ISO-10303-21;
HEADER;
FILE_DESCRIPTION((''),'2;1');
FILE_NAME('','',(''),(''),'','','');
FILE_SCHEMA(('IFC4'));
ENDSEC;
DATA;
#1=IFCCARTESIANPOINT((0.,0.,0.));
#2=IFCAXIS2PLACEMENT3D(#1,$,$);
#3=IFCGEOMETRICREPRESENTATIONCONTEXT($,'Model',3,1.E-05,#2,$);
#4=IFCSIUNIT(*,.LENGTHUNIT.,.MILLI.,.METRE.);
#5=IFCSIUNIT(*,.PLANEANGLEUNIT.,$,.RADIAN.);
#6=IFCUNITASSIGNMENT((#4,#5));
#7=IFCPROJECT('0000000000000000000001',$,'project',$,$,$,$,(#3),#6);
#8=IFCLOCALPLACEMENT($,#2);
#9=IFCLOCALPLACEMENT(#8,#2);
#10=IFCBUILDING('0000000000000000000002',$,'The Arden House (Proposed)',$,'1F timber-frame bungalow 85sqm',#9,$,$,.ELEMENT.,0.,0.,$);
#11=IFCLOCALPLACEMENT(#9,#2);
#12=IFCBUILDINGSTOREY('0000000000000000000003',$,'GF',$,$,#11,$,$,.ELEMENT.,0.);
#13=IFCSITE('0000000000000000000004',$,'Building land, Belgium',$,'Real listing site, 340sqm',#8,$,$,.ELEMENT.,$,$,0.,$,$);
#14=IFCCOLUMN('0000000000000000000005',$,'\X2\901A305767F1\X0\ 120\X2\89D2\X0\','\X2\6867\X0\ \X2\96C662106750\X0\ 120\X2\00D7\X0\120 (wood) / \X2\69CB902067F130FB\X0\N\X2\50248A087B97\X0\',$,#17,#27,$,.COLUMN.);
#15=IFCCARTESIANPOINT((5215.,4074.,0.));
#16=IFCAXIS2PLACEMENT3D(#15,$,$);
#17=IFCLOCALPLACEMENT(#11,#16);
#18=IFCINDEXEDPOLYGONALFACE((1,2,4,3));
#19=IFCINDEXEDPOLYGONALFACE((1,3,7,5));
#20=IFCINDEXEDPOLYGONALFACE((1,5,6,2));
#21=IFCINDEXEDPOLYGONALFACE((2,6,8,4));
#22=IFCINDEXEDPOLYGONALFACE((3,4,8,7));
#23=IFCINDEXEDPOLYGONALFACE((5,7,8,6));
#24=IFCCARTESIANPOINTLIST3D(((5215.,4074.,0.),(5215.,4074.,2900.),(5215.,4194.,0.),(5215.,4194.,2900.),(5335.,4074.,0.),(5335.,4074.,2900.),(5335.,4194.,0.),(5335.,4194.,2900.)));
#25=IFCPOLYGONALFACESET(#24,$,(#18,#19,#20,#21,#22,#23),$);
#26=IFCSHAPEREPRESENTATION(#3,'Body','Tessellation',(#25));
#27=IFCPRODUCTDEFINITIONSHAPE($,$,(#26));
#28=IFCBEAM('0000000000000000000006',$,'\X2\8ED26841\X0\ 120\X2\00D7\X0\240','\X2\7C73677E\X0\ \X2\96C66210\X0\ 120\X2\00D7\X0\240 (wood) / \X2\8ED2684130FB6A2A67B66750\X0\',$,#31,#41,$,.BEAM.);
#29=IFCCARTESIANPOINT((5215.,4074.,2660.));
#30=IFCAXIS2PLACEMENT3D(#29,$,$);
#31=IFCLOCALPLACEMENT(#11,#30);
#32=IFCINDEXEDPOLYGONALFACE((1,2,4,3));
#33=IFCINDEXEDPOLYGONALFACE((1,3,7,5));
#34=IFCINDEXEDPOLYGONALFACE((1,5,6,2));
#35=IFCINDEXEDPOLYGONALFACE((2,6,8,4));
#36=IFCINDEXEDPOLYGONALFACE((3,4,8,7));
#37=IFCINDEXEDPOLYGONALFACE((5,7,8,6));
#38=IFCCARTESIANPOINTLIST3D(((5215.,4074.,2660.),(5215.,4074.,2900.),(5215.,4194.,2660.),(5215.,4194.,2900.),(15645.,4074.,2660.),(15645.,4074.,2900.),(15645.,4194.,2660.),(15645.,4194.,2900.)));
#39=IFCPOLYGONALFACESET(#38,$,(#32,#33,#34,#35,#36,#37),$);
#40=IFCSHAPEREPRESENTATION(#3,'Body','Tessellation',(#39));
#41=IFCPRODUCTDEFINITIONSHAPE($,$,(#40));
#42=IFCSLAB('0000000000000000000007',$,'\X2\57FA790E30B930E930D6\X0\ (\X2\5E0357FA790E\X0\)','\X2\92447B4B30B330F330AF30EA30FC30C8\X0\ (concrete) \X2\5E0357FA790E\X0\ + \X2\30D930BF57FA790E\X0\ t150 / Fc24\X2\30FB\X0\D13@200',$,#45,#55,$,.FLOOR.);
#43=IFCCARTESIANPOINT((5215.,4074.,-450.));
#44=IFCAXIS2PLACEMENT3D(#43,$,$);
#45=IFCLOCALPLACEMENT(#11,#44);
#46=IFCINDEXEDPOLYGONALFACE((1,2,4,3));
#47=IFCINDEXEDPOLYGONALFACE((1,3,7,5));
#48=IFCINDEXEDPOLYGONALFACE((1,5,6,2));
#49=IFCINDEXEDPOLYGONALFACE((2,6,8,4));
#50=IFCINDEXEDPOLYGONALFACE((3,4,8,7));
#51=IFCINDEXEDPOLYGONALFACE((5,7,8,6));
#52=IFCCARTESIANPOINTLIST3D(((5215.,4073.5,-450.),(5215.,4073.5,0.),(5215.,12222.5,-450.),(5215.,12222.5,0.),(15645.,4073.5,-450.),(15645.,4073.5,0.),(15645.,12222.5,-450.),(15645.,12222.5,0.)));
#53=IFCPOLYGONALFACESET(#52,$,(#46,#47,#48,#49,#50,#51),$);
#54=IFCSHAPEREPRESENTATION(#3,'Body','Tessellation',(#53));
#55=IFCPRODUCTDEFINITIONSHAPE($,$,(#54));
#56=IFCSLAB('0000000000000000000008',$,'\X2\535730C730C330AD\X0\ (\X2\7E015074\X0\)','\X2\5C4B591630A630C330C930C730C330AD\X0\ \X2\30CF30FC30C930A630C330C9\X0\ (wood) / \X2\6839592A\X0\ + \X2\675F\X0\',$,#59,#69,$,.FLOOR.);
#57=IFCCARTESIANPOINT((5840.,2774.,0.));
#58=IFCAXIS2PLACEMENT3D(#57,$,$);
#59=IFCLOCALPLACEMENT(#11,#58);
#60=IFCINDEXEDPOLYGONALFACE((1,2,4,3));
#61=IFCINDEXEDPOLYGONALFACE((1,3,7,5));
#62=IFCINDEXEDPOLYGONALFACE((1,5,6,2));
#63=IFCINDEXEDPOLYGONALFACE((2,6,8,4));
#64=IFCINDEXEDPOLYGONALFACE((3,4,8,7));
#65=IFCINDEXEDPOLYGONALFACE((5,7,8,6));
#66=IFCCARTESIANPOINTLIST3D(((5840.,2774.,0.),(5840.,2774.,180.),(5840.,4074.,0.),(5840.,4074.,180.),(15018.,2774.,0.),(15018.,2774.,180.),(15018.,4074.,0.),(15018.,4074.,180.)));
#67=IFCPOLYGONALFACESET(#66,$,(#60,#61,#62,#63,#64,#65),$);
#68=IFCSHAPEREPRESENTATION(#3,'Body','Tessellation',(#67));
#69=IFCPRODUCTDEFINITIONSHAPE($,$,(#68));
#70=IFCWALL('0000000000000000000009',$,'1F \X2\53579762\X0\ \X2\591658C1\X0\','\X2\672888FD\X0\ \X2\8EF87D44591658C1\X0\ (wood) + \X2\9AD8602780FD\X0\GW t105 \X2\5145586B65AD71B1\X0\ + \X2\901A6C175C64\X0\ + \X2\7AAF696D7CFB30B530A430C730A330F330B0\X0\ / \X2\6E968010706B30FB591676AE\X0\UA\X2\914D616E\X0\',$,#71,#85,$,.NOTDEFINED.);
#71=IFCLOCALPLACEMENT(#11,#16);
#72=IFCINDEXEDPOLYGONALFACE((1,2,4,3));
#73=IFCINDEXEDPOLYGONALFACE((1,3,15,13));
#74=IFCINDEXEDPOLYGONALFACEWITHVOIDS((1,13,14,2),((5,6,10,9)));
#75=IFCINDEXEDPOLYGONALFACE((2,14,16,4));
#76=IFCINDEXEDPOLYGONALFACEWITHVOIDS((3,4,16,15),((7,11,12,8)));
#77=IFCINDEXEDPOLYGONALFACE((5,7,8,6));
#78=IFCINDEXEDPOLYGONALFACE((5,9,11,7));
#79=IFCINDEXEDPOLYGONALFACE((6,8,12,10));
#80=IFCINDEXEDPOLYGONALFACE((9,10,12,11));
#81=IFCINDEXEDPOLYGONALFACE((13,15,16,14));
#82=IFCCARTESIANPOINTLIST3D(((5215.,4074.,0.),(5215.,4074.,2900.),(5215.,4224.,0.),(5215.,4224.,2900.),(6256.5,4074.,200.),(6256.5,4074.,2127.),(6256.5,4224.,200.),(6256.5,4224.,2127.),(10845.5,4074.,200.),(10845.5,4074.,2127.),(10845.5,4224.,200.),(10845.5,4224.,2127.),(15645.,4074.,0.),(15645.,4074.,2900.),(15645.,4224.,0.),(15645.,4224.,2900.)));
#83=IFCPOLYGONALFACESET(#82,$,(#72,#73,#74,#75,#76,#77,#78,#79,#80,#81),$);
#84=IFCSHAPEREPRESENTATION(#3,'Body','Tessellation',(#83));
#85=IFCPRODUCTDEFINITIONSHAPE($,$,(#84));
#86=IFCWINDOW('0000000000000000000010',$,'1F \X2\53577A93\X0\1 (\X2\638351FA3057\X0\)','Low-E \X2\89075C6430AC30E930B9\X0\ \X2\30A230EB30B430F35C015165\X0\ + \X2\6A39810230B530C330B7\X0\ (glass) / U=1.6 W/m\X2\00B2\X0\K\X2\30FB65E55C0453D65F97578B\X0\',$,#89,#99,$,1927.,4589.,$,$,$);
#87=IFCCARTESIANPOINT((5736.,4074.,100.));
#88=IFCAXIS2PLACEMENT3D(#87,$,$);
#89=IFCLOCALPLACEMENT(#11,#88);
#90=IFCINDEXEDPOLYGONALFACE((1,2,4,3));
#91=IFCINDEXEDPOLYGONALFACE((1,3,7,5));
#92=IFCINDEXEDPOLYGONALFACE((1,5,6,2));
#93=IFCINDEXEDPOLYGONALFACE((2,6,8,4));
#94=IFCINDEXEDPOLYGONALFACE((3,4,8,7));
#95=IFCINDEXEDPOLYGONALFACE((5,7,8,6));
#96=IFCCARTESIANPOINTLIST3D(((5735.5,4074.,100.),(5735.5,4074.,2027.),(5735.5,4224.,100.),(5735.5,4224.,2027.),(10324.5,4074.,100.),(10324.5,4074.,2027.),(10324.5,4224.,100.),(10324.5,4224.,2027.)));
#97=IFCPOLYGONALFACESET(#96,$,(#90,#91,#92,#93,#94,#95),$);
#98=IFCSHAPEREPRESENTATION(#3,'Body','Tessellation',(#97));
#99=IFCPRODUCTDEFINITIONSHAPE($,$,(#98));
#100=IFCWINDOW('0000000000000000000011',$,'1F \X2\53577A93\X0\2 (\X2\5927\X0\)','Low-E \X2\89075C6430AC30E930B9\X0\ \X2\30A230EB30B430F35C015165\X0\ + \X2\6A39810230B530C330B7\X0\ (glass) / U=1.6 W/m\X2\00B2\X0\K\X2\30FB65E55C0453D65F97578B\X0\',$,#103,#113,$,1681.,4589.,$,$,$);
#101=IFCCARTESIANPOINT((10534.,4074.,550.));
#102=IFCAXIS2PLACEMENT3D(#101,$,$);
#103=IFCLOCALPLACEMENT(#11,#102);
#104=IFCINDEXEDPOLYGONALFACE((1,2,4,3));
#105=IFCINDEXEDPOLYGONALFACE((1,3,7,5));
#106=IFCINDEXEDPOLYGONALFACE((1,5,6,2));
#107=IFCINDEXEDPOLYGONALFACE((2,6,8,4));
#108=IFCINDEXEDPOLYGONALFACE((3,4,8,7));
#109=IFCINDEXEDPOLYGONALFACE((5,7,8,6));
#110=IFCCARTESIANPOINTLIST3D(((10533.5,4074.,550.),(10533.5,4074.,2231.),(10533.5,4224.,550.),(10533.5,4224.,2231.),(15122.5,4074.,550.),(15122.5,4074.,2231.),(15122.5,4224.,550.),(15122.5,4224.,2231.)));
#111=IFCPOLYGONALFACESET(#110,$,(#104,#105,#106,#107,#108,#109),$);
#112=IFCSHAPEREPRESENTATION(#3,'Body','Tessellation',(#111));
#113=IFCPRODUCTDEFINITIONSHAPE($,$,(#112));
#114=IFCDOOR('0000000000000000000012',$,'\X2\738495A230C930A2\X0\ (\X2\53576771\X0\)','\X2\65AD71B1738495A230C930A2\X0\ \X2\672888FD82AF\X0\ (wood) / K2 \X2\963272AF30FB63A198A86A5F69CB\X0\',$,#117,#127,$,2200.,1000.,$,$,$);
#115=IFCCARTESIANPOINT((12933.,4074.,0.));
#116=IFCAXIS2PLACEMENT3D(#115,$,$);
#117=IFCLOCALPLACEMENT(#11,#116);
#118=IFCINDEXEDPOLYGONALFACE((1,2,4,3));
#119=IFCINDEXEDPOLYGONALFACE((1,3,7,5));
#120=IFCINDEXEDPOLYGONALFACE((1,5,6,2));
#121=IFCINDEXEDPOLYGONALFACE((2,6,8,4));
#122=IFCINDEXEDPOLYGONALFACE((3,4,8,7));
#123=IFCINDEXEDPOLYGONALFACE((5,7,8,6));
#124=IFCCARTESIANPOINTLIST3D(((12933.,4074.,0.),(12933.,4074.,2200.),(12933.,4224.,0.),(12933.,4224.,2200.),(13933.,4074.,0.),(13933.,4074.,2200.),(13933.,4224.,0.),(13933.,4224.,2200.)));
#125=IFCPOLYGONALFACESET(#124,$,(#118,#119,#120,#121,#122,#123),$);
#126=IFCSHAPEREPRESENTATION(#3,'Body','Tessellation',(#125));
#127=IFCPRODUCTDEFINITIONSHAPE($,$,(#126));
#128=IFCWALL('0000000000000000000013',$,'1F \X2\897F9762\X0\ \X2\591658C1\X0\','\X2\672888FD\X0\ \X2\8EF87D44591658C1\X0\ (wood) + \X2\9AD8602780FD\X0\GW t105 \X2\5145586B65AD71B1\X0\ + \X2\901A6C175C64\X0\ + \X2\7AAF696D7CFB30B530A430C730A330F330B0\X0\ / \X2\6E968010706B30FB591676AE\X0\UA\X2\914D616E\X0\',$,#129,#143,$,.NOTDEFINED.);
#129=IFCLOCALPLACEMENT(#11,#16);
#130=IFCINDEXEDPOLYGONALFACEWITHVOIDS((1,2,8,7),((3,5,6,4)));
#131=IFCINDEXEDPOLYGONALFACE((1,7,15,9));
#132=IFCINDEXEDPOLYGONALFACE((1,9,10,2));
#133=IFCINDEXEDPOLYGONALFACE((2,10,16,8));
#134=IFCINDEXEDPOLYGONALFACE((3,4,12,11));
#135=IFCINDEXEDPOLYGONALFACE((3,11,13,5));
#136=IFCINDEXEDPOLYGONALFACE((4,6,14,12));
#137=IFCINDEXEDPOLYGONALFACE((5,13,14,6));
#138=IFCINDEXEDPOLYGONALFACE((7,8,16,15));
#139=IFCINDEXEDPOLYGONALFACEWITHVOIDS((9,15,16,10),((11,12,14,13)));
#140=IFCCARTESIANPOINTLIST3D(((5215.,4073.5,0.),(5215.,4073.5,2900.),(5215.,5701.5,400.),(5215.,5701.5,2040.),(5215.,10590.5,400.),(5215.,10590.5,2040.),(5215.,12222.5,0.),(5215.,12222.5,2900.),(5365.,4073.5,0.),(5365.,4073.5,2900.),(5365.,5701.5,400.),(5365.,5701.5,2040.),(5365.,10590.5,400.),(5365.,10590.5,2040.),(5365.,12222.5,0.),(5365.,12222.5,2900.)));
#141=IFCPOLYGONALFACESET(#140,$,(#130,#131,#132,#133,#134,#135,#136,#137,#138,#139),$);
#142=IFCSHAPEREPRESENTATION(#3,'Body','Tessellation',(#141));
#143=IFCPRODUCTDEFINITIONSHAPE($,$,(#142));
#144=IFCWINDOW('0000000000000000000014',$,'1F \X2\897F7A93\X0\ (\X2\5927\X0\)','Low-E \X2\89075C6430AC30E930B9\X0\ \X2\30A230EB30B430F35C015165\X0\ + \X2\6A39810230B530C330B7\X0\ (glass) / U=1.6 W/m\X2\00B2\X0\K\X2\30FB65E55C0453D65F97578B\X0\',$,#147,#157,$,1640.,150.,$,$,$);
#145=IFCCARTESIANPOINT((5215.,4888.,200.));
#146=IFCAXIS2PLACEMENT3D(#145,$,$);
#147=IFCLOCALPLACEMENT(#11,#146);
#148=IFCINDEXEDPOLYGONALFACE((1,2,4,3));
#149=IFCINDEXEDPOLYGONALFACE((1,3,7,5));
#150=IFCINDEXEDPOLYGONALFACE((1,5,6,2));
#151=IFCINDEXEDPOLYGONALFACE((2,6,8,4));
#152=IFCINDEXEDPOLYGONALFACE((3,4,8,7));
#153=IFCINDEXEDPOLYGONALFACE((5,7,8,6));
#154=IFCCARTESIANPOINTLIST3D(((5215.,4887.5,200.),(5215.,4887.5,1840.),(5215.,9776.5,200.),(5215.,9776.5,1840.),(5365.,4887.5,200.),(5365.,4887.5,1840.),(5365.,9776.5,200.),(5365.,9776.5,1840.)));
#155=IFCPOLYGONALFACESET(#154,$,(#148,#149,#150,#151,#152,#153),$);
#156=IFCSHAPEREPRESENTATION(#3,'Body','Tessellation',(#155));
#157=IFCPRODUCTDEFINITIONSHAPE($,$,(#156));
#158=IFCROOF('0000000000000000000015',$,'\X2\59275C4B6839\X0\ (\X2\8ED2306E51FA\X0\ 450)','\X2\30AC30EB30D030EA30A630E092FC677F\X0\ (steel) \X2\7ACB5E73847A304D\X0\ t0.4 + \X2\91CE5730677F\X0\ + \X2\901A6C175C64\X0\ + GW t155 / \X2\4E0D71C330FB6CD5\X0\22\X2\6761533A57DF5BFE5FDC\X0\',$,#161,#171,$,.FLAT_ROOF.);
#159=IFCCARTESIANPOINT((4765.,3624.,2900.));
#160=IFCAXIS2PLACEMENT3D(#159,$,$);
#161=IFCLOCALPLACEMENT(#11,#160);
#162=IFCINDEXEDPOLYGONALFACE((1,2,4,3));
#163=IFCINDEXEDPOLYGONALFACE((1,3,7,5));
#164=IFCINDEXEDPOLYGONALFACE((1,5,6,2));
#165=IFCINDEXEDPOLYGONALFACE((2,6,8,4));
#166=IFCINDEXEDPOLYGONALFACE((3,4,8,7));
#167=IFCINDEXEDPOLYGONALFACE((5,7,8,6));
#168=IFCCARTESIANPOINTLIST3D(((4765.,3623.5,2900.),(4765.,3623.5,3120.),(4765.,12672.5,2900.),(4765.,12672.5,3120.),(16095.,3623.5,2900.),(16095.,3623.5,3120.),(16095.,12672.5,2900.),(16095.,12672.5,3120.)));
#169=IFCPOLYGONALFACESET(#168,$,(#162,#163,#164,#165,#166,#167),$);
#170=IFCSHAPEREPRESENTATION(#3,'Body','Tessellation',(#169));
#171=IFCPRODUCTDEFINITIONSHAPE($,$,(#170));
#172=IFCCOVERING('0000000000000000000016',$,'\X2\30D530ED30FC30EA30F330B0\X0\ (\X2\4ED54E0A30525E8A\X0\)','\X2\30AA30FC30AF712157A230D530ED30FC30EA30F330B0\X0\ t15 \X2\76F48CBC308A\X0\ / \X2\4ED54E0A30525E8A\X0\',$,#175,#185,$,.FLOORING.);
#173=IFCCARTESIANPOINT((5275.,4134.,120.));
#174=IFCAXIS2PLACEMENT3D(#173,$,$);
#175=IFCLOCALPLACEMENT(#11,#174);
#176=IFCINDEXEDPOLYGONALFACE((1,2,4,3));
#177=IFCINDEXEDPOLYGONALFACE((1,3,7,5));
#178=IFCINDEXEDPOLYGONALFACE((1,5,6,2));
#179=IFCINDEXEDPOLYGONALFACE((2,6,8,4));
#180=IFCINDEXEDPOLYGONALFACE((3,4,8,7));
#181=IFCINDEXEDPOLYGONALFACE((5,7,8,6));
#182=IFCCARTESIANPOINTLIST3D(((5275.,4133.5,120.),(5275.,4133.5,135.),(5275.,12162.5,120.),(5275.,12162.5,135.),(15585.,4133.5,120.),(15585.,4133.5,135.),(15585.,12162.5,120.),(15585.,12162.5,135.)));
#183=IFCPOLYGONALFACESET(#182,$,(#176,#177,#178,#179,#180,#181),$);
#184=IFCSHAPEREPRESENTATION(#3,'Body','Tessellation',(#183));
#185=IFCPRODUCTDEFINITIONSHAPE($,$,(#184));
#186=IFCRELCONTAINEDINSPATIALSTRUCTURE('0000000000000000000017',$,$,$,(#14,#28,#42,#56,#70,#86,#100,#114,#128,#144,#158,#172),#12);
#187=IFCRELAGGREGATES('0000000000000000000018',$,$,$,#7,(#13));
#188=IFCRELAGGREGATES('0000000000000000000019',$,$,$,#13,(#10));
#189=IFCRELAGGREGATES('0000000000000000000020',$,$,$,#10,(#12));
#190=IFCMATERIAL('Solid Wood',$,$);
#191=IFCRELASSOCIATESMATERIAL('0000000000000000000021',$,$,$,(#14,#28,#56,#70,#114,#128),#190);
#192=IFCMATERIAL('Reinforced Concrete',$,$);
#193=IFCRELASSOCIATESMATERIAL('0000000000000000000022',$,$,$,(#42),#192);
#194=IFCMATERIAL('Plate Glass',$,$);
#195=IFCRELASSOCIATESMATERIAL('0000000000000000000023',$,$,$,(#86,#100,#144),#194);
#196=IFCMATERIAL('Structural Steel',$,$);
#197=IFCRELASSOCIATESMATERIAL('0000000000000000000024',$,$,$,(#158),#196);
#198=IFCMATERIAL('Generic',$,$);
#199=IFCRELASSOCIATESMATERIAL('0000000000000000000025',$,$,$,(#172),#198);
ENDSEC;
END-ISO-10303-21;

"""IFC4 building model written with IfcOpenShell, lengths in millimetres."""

from ifc_helpers import new_model, si_unit, frame, frame_2d, origin, place, context, project, spatial, rectangle, extrude, material, element, fill, save


model = new_model("IFC4")

# Units and contexts
model_context = context("Model", 3, precision=1e-05, world=origin())
ifc_project = project(units=[si_unit("LENGTHUNIT", "METRE", prefix="MILLI"), si_unit("PLANEANGLEUNIT", "RADIAN")], contexts=[model_context])

# Site, building, storey
site_placement = place(None, origin())
site = spatial("IfcSite", under=ifc_project, at=site_placement, Name="Building land, Belgium", ObjectType="Real listing site, 340sqm", CompositionType="ELEMENT", RefElevation=0.0)
building_placement = place(site_placement, origin())
building = spatial("IfcBuilding", under=site, at=building_placement, Name="The Arden House (Proposed)", ObjectType="1F timber-frame bungalow 85sqm", CompositionType="ELEMENT", ElevationOfRefHeight=0.0, ElevationOfTerrain=0.0)
storey_placement = place(building_placement, origin())
storey = spatial("IfcBuildingStorey", under=building, at=storey_placement, Name="GF", CompositionType="ELEMENT", Elevation=0.0)

# Column
ifc_material_1 = material(Name="Solid Wood")
column_1_placement = place(storey_placement, frame((5215.0, 4074.0, 0.0)))
element("IfcColumn", 1, at=column_1_placement, inside=storey, material=ifc_material_1, Name="通し柱 120角", Description="桧 集成材 120×120 (wood) / 構造柱・N値計算", PredefinedType="COLUMN", context=model_context, shape_type="SweptSolid", body=[
    extrude(rectangle(XDim=120.0, YDim=120.0, at=frame_2d((60.0, 60.0))), frame((5215.0, 4074.0, 0.0)), (0.0, 0.0, 1.0), 2900.0),
])

# Beam
beam_1_placement = place(storey_placement, frame((5215.0, 4074.0, 2660.0)))
element("IfcBeam", 2, at=beam_1_placement, inside=storey, material=ifc_material_1, Name="軒桁 120×240", Description="米松 集成 120×240 (wood) / 軒桁・横架材", PredefinedType="BEAM", context=model_context, shape_type="SweptSolid", body=[
    extrude(rectangle(XDim=10430.0, YDim=120.0, at=frame_2d((5215.0, 60.0))), frame((5215.0, 4074.0, 2660.0)), (0.0, 0.0, 1.0), 240.0),
])

# Slabs
ifc_material_2 = material(Name="Reinforced Concrete")
slab_1_placement = place(storey_placement, frame((5215.0, 4074.0, -450.0)))
element("IfcSlab", 3, at=slab_1_placement, inside=storey, material=ifc_material_2, Name="基礎スラブ (布基礎)", Description="鉄筋コンクリート (concrete) 布基礎 + ベタ基礎 t150 / Fc24・D13@200", PredefinedType="FLOOR", context=model_context, shape_type="SweptSolid", body=[
    extrude(rectangle(XDim=10430.0, YDim=8149.0, at=frame_2d((5215.0, 4074.0))), frame((5215.0, 4074.0, -450.0)), (0.0, 0.0, 1.0), 450.0),
])
slab_2_placement = place(storey_placement, frame((5840.0, 2774.0, 0.0)))
element("IfcSlab", 4, at=slab_2_placement, inside=storey, material=ifc_material_1, Name="南デッキ (縁側)", Description="屋外ウッドデッキ ハードウッド (wood) / 根太 + 束", PredefinedType="FLOOR", context=model_context, shape_type="SweptSolid", body=[
    extrude(rectangle(XDim=9178.0, YDim=1300.0, at=frame_2d((4589.0, 650.0))), frame((5840.0, 2774.0, 0.0)), (0.0, 0.0, 1.0), 180.0),
])

# Wall, openings, windows, door
wall_1_placement = place(storey_placement, frame((5215.0, 4074.0, 0.0)))
wall_1 = element("IfcWall", 5, at=wall_1_placement, inside=storey, material=ifc_material_1, Name="1F 南面 外壁", Description="木製 軸組外壁 (wood) + 高性能GW t105 充填断熱 + 通気層 + 窯業系サイディング / 準耐火・外皮UA配慮", PredefinedType="NOTDEFINED", context=model_context, shape_type="SweptSolid", body=[
    extrude(rectangle(XDim=10430.0, YDim=150.0, at=frame_2d((5215.0, 75.0))), frame((5215.0, 4074.0, 0.0)), (0.0, 0.0, 1.0), 2900.0),
])
opening_1_placement = place(storey_placement, frame((5736.0, 4074.0, 100.0)))
opening_1 = element("IfcOpeningElement", 6, at=opening_1_placement, cuts=wall_1, PredefinedType="NOTDEFINED", context=model_context, shape_type="SweptSolid", body=[
    extrude(rectangle(XDim=4589.0, YDim=150.0, at=frame_2d((2294.0, 75.0))), frame((5736.0, 4074.0, 100.0)), (0.0, 0.0, 1.0), 1927.0),
])
opening_2_placement = place(storey_placement, frame((10534.0, 4074.0, 550.0)))
opening_2 = element("IfcOpeningElement", 7, at=opening_2_placement, cuts=wall_1, PredefinedType="NOTDEFINED", context=model_context, shape_type="SweptSolid", body=[
    extrude(rectangle(XDim=4589.0, YDim=150.0, at=frame_2d((2294.0, 75.0))), frame((10534.0, 4074.0, 550.0)), (0.0, 0.0, 1.0), 1681.0),
])
opening_3_placement = place(storey_placement, frame((12933.0, 4074.0, 0.0)))
opening_3 = element("IfcOpeningElement", 8, at=opening_3_placement, cuts=wall_1, PredefinedType="NOTDEFINED", context=model_context, shape_type="SweptSolid", body=[
    extrude(rectangle(XDim=1000.0, YDim=150.0, at=frame_2d((500.0, 75.0))), frame((12933.0, 4074.0, 0.0)), (0.0, 0.0, 1.0), 2200.0),
])
ifc_material_3 = material(Name="Plate Glass")
window_1_placement = place(storey_placement, frame((5736.0, 4074.0, 100.0)))
window_1 = element("IfcWindow", 9, at=window_1_placement, inside=storey, material=ifc_material_3, Name="1F 南窓1 (掃出し)", Description="Low-E 複層ガラス アルゴン封入 + 樹脂サッシ (glass) / U=1.6 W/m²K・日射取得型", OverallHeight=1927.0, OverallWidth=4589.0, context=model_context, shape_type="SweptSolid", body=[
    extrude(rectangle(XDim=4589.0, YDim=150.0, at=frame_2d((2294.0, 75.0))), frame((5736.0, 4074.0, 100.0)), (0.0, 0.0, 1.0), 1927.0),
])
fill(opening_1, window_1)
window_2_placement = place(storey_placement, frame((10534.0, 4074.0, 550.0)))
window_2 = element("IfcWindow", 10, at=window_2_placement, inside=storey, material=ifc_material_3, Name="1F 南窓2 (大)", Description="Low-E 複層ガラス アルゴン封入 + 樹脂サッシ (glass) / U=1.6 W/m²K・日射取得型", OverallHeight=1681.0, OverallWidth=4589.0, context=model_context, shape_type="SweptSolid", body=[
    extrude(rectangle(XDim=4589.0, YDim=150.0, at=frame_2d((2294.0, 75.0))), frame((10534.0, 4074.0, 550.0)), (0.0, 0.0, 1.0), 1681.0),
])
fill(opening_2, window_2)
door_placement = place(storey_placement, frame((12933.0, 4074.0, 0.0)))
door = element("IfcDoor", 11, at=door_placement, inside=storey, material=ifc_material_1, Name="玄関ドア (南東)", Description="断熱玄関ドア 木製芯 (wood) / K2 防犯・採風機構", OverallHeight=2200.0, OverallWidth=1000.0, context=model_context, shape_type="SweptSolid", body=[
    extrude(rectangle(XDim=1000.0, YDim=150.0, at=frame_2d((500.0, 75.0))), frame((12933.0, 4074.0, 0.0)), (0.0, 0.0, 1.0), 2200.0),
])
fill(opening_3, door)

# Wall, opening, window
wall_2_placement = place(storey_placement, frame((5215.0, 4074.0, 0.0)))
wall_2 = element("IfcWall", 12, at=wall_2_placement, inside=storey, material=ifc_material_1, Name="1F 西面 外壁", Description="木製 軸組外壁 (wood) + 高性能GW t105 充填断熱 + 通気層 + 窯業系サイディング / 準耐火・外皮UA配慮", PredefinedType="NOTDEFINED", context=model_context, shape_type="SweptSolid", body=[
    extrude(rectangle(XDim=150.0, YDim=8149.0, at=frame_2d((75.0, 4074.0))), frame((5215.0, 4074.0, 0.0)), (0.0, 0.0, 1.0), 2900.0),
])
opening_4_placement = place(storey_placement, frame((5215.0, 4888.0, 200.0)))
opening_4 = element("IfcOpeningElement", 13, at=opening_4_placement, cuts=wall_2, PredefinedType="NOTDEFINED", context=model_context, shape_type="SweptSolid", body=[
    extrude(rectangle(XDim=150.0, YDim=4889.0, at=frame_2d((75.0, 2444.0))), frame((5215.0, 4888.0, 200.0)), (0.0, 0.0, 1.0), 1640.0),
])
window_3_placement = place(storey_placement, frame((5215.0, 4888.0, 200.0)))
window_3 = element("IfcWindow", 14, at=window_3_placement, inside=storey, material=ifc_material_3, Name="1F 西窓 (大)", Description="Low-E 複層ガラス アルゴン封入 + 樹脂サッシ (glass) / U=1.6 W/m²K・日射取得型", OverallHeight=1640.0, OverallWidth=150.0, context=model_context, shape_type="SweptSolid", body=[
    extrude(rectangle(XDim=150.0, YDim=4889.0, at=frame_2d((75.0, 2444.0))), frame((5215.0, 4888.0, 200.0)), (0.0, 0.0, 1.0), 1640.0),
])
fill(opening_4, window_3)

# Roof
ifc_material_4 = material(Name="Structural Steel")
roof_placement = place(storey_placement, frame((4765.0, 3624.0, 2900.0)))
element("IfcRoof", 15, at=roof_placement, inside=storey, material=ifc_material_4, Name="大屋根 (軒の出 450)", Description="ガルバリウム鋼板 (steel) 立平葺き t0.4 + 野地板 + 通気層 + GW t155 / 不燃・法22条区域対応", PredefinedType="FLAT_ROOF", context=model_context, shape_type="SweptSolid", body=[
    extrude(rectangle(XDim=11330.0, YDim=9049.0, at=frame_2d((5665.0, 4524.0))), frame((4765.0, 3624.0, 2900.0)), (0.0, 0.0, 1.0), 220.0),
])

# Covering
ifc_material_5 = material(Name="Generic")
covering_1_placement = place(storey_placement, frame((5275.0, 4134.0, 120.0)))
element("IfcCovering", 16, at=covering_1_placement, inside=storey, material=ifc_material_5, Name="フローリング (仕上げ床)", Description="オーク無垢フローリング t15 直貼り / 仕上げ床", PredefinedType="FLOORING", context=model_context, shape_type="SweptSolid", body=[
    extrude(rectangle(XDim=10310.0, YDim=8029.0, at=frame_2d((5155.0, 4014.0))), frame((5275.0, 4134.0, 120.0)), (0.0, 0.0, 1.0), 15.0),
])

save(model, "model.ifc")
